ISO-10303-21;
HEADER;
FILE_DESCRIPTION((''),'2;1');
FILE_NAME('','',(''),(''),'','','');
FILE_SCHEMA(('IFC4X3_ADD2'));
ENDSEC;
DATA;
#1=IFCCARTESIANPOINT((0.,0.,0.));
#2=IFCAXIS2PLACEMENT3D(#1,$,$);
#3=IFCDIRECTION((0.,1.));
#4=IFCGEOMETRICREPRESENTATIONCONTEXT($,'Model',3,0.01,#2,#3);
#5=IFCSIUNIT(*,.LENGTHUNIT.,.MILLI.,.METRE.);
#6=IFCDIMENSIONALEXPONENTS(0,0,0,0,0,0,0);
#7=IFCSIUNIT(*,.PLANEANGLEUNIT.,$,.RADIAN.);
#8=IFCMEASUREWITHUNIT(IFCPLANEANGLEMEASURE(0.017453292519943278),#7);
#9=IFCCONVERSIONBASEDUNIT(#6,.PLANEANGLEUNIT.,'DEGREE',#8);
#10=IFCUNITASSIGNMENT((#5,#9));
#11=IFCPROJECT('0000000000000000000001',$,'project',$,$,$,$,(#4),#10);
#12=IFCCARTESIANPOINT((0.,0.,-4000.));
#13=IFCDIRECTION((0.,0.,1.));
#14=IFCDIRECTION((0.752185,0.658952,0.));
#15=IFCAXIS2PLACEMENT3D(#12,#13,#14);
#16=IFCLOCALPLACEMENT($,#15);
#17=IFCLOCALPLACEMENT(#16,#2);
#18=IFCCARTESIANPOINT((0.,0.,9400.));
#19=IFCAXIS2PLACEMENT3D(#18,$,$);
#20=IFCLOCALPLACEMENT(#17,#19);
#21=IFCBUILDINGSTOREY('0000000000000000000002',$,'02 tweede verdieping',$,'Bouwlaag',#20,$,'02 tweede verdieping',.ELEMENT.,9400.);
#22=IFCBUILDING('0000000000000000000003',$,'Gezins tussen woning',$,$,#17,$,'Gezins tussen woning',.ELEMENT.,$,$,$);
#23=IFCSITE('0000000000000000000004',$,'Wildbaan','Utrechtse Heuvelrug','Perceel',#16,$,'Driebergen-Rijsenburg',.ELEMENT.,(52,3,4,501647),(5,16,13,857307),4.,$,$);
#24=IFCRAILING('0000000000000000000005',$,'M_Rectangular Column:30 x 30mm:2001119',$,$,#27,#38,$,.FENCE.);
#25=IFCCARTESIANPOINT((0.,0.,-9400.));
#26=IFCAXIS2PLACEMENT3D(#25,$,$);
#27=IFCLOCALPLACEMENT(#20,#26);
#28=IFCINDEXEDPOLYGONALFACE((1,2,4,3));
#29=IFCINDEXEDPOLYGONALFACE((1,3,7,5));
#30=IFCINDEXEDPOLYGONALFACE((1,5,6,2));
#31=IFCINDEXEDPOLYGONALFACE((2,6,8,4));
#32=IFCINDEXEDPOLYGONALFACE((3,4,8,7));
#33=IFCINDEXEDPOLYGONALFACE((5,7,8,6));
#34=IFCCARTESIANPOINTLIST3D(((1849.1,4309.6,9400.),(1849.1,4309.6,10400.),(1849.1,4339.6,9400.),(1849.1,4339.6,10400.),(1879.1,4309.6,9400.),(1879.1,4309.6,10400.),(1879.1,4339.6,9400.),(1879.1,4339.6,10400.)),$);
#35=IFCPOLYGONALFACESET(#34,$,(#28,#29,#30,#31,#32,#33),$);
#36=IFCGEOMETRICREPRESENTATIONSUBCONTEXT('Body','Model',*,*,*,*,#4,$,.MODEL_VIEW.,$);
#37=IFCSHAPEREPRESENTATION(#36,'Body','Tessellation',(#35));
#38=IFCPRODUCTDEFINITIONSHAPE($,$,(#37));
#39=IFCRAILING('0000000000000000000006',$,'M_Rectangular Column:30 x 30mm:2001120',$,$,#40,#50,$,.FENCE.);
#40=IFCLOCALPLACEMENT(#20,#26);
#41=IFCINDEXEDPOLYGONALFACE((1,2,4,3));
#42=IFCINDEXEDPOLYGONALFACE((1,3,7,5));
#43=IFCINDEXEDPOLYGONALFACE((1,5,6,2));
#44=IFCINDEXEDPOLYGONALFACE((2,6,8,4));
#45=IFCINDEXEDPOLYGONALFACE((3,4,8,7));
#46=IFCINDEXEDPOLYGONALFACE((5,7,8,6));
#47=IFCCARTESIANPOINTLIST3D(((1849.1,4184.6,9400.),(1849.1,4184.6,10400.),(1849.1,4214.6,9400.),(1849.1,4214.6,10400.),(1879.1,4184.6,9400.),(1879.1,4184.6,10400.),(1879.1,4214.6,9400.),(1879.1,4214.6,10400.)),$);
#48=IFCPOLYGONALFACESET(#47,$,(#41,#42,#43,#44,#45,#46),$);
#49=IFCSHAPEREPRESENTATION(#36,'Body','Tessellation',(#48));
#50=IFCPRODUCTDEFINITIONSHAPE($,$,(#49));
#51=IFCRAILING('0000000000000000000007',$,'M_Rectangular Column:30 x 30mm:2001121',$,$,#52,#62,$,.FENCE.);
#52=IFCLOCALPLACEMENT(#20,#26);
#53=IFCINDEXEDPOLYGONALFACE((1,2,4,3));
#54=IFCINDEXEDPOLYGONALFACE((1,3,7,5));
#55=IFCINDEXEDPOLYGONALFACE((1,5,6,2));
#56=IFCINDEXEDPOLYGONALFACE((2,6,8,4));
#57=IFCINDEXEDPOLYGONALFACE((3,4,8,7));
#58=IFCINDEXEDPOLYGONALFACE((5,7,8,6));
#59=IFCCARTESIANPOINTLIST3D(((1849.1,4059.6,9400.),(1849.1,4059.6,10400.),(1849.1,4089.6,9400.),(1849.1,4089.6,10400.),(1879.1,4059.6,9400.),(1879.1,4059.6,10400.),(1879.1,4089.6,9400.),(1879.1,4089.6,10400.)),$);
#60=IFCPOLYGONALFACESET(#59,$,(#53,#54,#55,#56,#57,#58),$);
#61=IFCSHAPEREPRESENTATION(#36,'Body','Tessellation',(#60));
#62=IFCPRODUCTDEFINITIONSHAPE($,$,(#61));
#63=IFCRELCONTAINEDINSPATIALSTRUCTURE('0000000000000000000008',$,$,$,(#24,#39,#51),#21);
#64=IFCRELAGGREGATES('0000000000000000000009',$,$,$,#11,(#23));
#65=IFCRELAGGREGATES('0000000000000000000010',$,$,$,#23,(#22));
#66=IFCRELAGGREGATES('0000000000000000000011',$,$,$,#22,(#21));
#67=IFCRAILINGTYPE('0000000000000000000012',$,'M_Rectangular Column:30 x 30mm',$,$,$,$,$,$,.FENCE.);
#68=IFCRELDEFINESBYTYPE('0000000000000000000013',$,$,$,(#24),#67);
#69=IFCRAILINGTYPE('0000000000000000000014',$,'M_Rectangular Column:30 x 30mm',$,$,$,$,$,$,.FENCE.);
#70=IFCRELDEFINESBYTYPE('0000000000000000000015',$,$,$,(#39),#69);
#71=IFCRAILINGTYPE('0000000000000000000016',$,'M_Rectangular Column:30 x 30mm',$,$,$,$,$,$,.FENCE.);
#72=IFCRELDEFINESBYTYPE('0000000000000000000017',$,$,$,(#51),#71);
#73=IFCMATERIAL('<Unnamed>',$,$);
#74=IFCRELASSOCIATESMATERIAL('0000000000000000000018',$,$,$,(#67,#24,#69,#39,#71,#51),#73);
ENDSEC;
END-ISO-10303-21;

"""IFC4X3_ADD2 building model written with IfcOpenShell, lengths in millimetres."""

from ifc_helpers import new_model, entity, si_unit, converted_unit, direction, frame, frame_2d, origin, place, context, subcontext, project, spatial, rectangle, extrude, source, transform, mapped, material, type_object, type_shapes, element, save


model = new_model("IFC4X3_ADD2")

# Units and contexts
model_context = context("Model", 3, precision=0.01, world=origin(), true_north=direction((0.0, 1.0)))
body_context = subcontext(model_context, "Body", "Model", "MODEL_VIEW")
ifc_project = project(units=[si_unit("LENGTHUNIT", "METRE", prefix="MILLI"), converted_unit("PLANEANGLEUNIT", "DEGREE", entity("IfcPlaneAngleMeasure", 0.017453292519943278), si_unit("PLANEANGLEUNIT", "RADIAN"), dimensions=[0, 0, 0, 0, 0, 0, 0])], contexts=[model_context])

# Site, building, storey
site_placement = place(None, frame((0.0, 0.0, -4000.0), z_axis=(0.0, 0.0, 1.0), x_axis=(0.752185, 0.658952, 0.0)))
site = spatial("IfcSite", under=ifc_project, at=site_placement, Name="Wildbaan", Description="Utrechtse Heuvelrug", ObjectType="Perceel", LongName="Driebergen-Rijsenburg", CompositionType="ELEMENT", RefLatitude=(52, 3, 4, 501647), RefLongitude=(5, 16, 13, 857307), RefElevation=4.0)
building_placement = place(site_placement, origin())
building = spatial("IfcBuilding", under=site, at=building_placement, Name="Gezins tussen woning", LongName="Gezins tussen woning", CompositionType="ELEMENT")
storey_placement = place(building_placement, frame((0.0, 0.0, 9400.0)))
storey = spatial("IfcBuildingStorey", under=building, at=storey_placement, Name="02 tweede verdieping", ObjectType="Bouwlaag", LongName="02 tweede verdieping", CompositionType="ELEMENT", Elevation=9400.0)

# Railings
ifc_material_1 = material(Name="<Unnamed>")
railing_type_1 = type_object("IfcRailingType", Name="M_Rectangular Column:30 x 30mm", PredefinedType="FENCE", material=ifc_material_1)
shared_shape_1 = source(origin(), body_context, "Body", "SweptSolid", [
    extrude(rectangle(XDim=30.0, YDim=30.0, at=frame_2d((0.0, 0.0), x_axis=(1.0, 0.0))), frame((1864.1, 4324.6, 9400.0), z_axis=(0.0, 0.0, 1.0), x_axis=(-1.0, 0.0, 0.0)), (0.0, 0.0, 1.0), 1000.0),
])
type_shapes(railing_type_1, [shared_shape_1])
railing_1_placement = place(storey_placement, frame((0.0, 0.0, -9400.0)))
element("IfcRailing", 1, at=railing_1_placement, inside=storey, type_object=railing_type_1, material=ifc_material_1, Name="M_Rectangular Column:30 x 30mm:2001119", PredefinedType="FENCE", context=body_context, shape_type="MappedRepresentation", body=[
    mapped(shared_shape_1, transform((0.0, 0.0, 0.0), scale=1.0)),
])
railing_type_2 = type_object("IfcRailingType", Name="M_Rectangular Column:30 x 30mm", PredefinedType="FENCE", material=ifc_material_1)
shared_shape_2 = source(origin(), body_context, "Body", "SweptSolid", [
    extrude(rectangle(XDim=30.0, YDim=30.0, at=frame_2d((0.0, 0.0), x_axis=(1.0, 0.0))), frame((1864.1, 4199.6, 9400.0), z_axis=(0.0, 0.0, 1.0), x_axis=(-1.0, 0.0, 0.0)), (0.0, 0.0, 1.0), 1000.0),
])
type_shapes(railing_type_2, [shared_shape_2])
railing_2_placement = place(storey_placement, frame((0.0, 0.0, -9400.0)))
element("IfcRailing", 2, at=railing_2_placement, inside=storey, type_object=railing_type_2, material=ifc_material_1, Name="M_Rectangular Column:30 x 30mm:2001120", PredefinedType="FENCE", context=body_context, shape_type="MappedRepresentation", body=[
    mapped(shared_shape_2, transform((0.0, 0.0, 0.0), scale=1.0)),
])
railing_type_3 = type_object("IfcRailingType", Name="M_Rectangular Column:30 x 30mm", PredefinedType="FENCE", material=ifc_material_1)
shared_shape_3 = source(origin(), body_context, "Body", "SweptSolid", [
    extrude(rectangle(XDim=30.0, YDim=30.0, at=frame_2d((0.0, 0.0), x_axis=(1.0, 0.0))), frame((1864.1, 4074.6, 9400.0), z_axis=(0.0, 0.0, 1.0), x_axis=(-1.0, 0.0, 0.0)), (0.0, 0.0, 1.0), 1000.0),
])
type_shapes(railing_type_3, [shared_shape_3])
railing_3_placement = place(storey_placement, frame((0.0, 0.0, -9400.0)))
element("IfcRailing", 3, at=railing_3_placement, inside=storey, type_object=railing_type_3, material=ifc_material_1, Name="M_Rectangular Column:30 x 30mm:2001121", PredefinedType="FENCE", context=body_context, shape_type="MappedRepresentation", body=[
    mapped(shared_shape_3, transform((0.0, 0.0, 0.0), scale=1.0)),
])

save(model, "model.ifc")
